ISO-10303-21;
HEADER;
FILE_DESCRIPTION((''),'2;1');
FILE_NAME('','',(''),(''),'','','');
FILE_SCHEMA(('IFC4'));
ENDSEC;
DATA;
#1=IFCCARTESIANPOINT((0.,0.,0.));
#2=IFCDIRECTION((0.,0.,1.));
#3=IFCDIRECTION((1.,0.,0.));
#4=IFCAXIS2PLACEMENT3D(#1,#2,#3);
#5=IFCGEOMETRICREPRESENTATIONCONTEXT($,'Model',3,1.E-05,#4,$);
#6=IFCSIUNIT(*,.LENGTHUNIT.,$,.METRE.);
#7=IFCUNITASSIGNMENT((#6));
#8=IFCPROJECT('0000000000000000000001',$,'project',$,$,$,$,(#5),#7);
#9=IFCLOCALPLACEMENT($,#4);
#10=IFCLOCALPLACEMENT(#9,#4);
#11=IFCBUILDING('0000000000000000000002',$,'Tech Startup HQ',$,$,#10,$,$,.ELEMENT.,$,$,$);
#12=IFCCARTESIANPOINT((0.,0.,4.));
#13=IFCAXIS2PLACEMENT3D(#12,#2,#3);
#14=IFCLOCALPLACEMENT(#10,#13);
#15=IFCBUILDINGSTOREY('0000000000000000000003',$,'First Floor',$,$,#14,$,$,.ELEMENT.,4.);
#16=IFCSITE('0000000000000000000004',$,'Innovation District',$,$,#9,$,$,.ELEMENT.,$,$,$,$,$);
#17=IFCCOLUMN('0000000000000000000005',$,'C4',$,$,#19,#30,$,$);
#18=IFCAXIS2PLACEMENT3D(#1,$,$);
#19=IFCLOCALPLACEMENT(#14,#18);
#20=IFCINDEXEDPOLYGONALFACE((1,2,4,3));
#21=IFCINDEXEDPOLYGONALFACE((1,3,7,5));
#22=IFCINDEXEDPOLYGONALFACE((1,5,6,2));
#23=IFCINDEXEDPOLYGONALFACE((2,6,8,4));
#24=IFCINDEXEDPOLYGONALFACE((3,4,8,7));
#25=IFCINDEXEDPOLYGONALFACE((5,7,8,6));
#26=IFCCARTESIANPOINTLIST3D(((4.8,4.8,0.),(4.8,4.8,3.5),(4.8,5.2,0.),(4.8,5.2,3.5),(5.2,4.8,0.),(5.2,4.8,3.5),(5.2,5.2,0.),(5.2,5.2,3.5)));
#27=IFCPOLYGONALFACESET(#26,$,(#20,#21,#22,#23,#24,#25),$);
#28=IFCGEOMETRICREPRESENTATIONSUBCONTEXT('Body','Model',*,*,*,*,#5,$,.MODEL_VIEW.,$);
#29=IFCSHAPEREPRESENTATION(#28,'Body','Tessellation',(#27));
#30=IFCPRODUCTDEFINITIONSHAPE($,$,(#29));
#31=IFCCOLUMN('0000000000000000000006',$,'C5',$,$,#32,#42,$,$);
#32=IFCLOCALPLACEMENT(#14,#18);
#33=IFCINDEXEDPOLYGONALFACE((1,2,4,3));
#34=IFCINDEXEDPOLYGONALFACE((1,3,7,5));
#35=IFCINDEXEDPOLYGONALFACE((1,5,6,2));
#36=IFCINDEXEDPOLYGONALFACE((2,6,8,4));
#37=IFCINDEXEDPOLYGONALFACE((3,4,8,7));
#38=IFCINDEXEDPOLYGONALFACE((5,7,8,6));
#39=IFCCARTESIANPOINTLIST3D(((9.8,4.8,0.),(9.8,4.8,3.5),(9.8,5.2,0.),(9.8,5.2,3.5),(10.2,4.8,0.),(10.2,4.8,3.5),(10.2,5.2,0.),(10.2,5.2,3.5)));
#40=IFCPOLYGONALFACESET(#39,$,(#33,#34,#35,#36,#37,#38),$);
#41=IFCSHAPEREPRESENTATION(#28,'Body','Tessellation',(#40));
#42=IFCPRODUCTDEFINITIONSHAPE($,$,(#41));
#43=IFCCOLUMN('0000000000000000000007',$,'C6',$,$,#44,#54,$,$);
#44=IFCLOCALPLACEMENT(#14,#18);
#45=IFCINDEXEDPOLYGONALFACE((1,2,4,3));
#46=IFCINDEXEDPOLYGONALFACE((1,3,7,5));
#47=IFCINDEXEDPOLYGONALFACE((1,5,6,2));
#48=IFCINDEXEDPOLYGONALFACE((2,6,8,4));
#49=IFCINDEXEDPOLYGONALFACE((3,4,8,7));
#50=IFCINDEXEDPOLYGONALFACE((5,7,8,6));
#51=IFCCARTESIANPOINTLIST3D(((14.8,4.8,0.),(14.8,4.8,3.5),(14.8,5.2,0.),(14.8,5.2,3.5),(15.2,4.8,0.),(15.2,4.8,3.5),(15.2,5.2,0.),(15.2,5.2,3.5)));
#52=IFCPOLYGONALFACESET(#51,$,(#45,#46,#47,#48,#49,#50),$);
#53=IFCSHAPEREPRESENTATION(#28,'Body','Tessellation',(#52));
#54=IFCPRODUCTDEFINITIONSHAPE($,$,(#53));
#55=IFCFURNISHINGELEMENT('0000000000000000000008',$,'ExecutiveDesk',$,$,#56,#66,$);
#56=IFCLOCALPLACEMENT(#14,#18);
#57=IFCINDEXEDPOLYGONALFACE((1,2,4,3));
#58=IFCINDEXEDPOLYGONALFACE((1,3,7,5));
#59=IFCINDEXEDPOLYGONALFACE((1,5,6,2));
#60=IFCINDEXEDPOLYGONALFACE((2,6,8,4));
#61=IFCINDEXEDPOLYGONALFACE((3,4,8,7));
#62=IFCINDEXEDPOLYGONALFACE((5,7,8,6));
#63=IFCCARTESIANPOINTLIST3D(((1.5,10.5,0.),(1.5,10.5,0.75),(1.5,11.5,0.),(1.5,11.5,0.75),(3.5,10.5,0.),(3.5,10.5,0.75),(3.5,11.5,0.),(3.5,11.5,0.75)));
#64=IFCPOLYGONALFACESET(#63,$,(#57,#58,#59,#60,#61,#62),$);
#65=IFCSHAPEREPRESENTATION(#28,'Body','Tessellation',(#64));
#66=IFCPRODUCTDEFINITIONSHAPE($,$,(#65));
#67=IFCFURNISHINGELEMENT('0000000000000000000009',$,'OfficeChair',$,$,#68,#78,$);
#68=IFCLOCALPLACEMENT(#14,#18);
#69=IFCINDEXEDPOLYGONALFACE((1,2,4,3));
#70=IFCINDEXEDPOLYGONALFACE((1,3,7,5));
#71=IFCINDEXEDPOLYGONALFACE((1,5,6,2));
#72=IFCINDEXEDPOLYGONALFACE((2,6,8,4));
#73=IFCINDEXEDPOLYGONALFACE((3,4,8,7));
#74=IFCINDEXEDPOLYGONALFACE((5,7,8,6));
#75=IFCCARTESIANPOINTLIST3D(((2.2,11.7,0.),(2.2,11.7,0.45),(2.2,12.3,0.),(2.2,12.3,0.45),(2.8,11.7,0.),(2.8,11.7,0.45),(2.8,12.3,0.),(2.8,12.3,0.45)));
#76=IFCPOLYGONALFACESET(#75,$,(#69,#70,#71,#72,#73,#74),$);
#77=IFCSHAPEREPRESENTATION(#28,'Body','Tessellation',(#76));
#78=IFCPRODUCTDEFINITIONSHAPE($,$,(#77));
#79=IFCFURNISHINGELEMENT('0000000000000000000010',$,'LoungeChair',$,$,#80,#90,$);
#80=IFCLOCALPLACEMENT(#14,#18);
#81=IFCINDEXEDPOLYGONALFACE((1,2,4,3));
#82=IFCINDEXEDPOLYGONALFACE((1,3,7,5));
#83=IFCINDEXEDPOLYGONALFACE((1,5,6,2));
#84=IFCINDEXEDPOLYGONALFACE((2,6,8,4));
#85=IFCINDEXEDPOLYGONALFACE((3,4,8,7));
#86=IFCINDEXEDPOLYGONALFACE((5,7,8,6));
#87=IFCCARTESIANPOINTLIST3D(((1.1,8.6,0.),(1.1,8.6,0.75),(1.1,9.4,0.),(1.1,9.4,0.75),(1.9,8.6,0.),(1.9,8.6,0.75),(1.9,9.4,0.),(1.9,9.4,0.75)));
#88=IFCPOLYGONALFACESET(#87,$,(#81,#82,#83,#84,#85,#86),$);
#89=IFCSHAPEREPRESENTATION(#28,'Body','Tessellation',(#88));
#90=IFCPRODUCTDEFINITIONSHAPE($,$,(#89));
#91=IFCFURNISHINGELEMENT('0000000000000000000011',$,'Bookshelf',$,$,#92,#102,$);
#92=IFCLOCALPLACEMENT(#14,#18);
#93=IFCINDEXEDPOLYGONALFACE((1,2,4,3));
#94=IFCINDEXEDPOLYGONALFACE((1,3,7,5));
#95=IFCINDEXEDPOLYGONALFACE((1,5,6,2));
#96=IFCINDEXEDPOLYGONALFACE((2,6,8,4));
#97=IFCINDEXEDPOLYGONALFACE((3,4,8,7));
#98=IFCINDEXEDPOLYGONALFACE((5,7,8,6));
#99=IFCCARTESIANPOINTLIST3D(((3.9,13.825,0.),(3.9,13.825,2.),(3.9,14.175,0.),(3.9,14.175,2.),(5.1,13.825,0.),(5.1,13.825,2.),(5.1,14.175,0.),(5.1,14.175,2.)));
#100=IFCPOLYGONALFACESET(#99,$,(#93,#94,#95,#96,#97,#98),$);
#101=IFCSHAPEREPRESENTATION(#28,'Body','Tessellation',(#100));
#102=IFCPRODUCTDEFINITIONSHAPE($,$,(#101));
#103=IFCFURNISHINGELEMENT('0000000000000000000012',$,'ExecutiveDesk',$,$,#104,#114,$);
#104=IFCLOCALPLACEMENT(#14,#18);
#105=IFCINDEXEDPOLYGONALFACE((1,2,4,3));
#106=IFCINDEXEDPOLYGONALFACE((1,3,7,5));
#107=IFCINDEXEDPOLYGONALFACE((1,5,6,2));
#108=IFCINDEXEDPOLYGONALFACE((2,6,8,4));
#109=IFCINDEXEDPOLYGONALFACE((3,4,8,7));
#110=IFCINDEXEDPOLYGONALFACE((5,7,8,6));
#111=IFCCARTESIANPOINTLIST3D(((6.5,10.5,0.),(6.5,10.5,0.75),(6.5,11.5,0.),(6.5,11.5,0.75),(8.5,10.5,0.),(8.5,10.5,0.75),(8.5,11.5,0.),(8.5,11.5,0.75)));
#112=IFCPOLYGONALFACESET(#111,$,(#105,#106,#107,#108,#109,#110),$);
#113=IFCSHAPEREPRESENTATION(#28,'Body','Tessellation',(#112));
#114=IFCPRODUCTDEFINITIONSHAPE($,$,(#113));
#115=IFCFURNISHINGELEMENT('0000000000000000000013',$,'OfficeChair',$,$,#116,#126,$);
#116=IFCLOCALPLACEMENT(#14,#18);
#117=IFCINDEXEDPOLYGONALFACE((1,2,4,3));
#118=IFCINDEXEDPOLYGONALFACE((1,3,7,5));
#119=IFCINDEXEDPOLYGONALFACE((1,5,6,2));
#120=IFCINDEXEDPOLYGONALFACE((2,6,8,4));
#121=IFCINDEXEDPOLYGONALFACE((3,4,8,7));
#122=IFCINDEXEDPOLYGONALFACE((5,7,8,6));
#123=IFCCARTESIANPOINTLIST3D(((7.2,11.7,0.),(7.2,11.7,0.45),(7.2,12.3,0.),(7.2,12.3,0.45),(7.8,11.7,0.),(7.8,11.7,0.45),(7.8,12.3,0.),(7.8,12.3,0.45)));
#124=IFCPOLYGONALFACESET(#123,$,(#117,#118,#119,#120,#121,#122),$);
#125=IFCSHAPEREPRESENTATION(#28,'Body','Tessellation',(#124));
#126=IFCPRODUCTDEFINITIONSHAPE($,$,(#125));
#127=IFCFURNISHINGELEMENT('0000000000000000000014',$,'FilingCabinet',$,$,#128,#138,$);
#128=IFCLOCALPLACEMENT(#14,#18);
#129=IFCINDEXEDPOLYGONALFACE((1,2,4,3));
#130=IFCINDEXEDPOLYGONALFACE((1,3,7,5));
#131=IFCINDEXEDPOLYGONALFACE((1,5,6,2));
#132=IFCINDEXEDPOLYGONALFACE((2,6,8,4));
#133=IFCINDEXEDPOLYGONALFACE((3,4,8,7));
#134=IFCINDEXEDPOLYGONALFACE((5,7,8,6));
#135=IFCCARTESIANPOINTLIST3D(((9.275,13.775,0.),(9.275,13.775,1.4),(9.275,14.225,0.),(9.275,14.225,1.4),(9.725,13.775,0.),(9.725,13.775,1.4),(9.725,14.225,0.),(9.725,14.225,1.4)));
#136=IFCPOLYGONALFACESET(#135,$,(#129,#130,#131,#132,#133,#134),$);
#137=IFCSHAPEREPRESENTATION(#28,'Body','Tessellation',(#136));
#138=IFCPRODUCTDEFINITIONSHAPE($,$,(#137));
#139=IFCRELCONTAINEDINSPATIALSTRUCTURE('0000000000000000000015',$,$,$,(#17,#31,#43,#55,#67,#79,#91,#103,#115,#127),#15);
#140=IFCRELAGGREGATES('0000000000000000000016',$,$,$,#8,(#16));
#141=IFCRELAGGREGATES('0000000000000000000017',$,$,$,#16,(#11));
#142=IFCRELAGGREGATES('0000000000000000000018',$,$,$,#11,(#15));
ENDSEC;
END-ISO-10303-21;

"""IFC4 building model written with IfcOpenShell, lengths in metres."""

from ifc_helpers import new_model, si_unit, frame, origin_with_axes, place, context, subcontext, project, spatial, polyline, outline, extrude, element, save


model = new_model("IFC4")

# Units and contexts
model_context = context("Model", 3, precision=1e-05, world=origin_with_axes())
body_context = subcontext(model_context, "Body", "Model", "MODEL_VIEW")
ifc_project = project(units=[si_unit("LENGTHUNIT", "METRE")], contexts=[model_context])

# Site, building, storey
site_placement = place(None, origin_with_axes())
site = spatial("IfcSite", under=ifc_project, at=site_placement, Name="Innovation District", CompositionType="ELEMENT")
building_placement = place(site_placement, origin_with_axes())
building = spatial("IfcBuilding", under=site, at=building_placement, Name="Tech Startup HQ", CompositionType="ELEMENT")
storey_placement = place(building_placement, frame((0.0, 0.0, 4.0), z_axis=(0.0, 0.0, 1.0), x_axis=(1.0, 0.0, 0.0)))
storey = spatial("IfcBuildingStorey", under=building, at=storey_placement, Name="First Floor", CompositionType="ELEMENT", Elevation=4.0)

# Columns
column_1_placement = place(storey_placement, origin_with_axes())
element("IfcColumn", 1, at=column_1_placement, inside=storey, Name="C4", context=body_context, shape_type="SweptSolid", body=[
    extrude(outline(polyline([(4.8, 4.8, 0.0), (5.2, 4.8, 0.0), (5.2, 5.2, 0.0), (4.8, 5.2, 0.0), (4.8, 4.8, 0.0)])), None, (0.0, 0.0, 1.0), 3.5),
])
column_2_placement = place(storey_placement, origin_with_axes())
element("IfcColumn", 2, at=column_2_placement, inside=storey, Name="C5", context=body_context, shape_type="SweptSolid", body=[
    extrude(outline(polyline([(9.8, 4.8, 0.0), (10.2, 4.8, 0.0), (10.2, 5.2, 0.0), (9.8, 5.2, 0.0), (9.8, 4.8, 0.0)])), None, (0.0, 0.0, 1.0), 3.5),
])
column_3_placement = place(storey_placement, origin_with_axes())
element("IfcColumn", 3, at=column_3_placement, inside=storey, Name="C6", context=body_context, shape_type="SweptSolid", body=[
    extrude(outline(polyline([(14.8, 4.8, 0.0), (15.2, 4.8, 0.0), (15.2, 5.2, 0.0), (14.8, 5.2, 0.0), (14.8, 4.8, 0.0)])), None, (0.0, 0.0, 1.0), 3.5),
])

# Furnishing elements
furnishing_1_placement = place(storey_placement, origin_with_axes())
element("IfcFurnishingElement", 4, at=furnishing_1_placement, inside=storey, Name="ExecutiveDesk", context=body_context, shape_type="SweptSolid", body=[
    extrude(outline(polyline([(3.5, 11.5, 0.0), (1.5, 11.5, 0.0), (1.5, 10.5, 0.0), (3.5, 10.5, 0.0), (3.5, 11.5, 0.0)])), None, (0.0, 0.0, 1.0), 0.75),
])
furnishing_2_placement = place(storey_placement, origin_with_axes())
element("IfcFurnishingElement", 5, at=furnishing_2_placement, inside=storey, Name="OfficeChair", context=body_context, shape_type="SweptSolid", body=[
    extrude(outline(polyline([(2.8, 12.3, 0.0), (2.2, 12.3, 0.0), (2.2, 11.7, 0.0), (2.8, 11.7, 0.0), (2.8, 12.3, 0.0)])), None, (0.0, 0.0, 1.0), 0.45),
])
furnishing_3_placement = place(storey_placement, origin_with_axes())
element("IfcFurnishingElement", 6, at=furnishing_3_placement, inside=storey, Name="LoungeChair", context=body_context, shape_type="SweptSolid", body=[
    extrude(outline(polyline([(1.1, 9.4, 0.0), (1.1, 8.6, 0.0), (1.9, 8.6, 0.0), (1.9, 9.4, 0.0), (1.1, 9.4, 0.0)])), None, (0.0, 0.0, 1.0), 0.75),
])
furnishing_4_placement = place(storey_placement, origin_with_axes())
element("IfcFurnishingElement", 7, at=furnishing_4_placement, inside=storey, Name="Bookshelf", context=body_context, shape_type="SweptSolid", body=[
    extrude(outline(polyline([(3.9, 13.825, 0.0), (5.1, 13.825, 0.0), (5.1, 14.175, 0.0), (3.9, 14.175, 0.0), (3.9, 13.825, 0.0)])), None, (0.0, 0.0, 1.0), 2.0),
])
furnishing_5_placement = place(storey_placement, origin_with_axes())
element("IfcFurnishingElement", 8, at=furnishing_5_placement, inside=storey, Name="ExecutiveDesk", context=body_context, shape_type="SweptSolid", body=[
    extrude(outline(polyline([(8.5, 11.5, 0.0), (6.5, 11.5, 0.0), (6.5, 10.5, 0.0), (8.5, 10.5, 0.0), (8.5, 11.5, 0.0)])), None, (0.0, 0.0, 1.0), 0.75),
])
furnishing_6_placement = place(storey_placement, origin_with_axes())
element("IfcFurnishingElement", 9, at=furnishing_6_placement, inside=storey, Name="OfficeChair", context=body_context, shape_type="SweptSolid", body=[
    extrude(outline(polyline([(7.8, 12.3, 0.0), (7.2, 12.3, 0.0), (7.2, 11.7, 0.0), (7.8, 11.7, 0.0), (7.8, 12.3, 0.0)])), None, (0.0, 0.0, 1.0), 0.45),
])
furnishing_7_placement = place(storey_placement, origin_with_axes())
element("IfcFurnishingElement", 10, at=furnishing_7_placement, inside=storey, Name="FilingCabinet", context=body_context, shape_type="SweptSolid", body=[
    extrude(outline(polyline([(9.275, 13.775, 0.0), (9.725, 13.775, 0.0), (9.725, 14.225, 0.0), (9.275, 14.225, 0.0), (9.275, 13.775, 0.0)])), None, (0.0, 0.0, 1.0), 1.4),
])

save(model, "model.ifc")
